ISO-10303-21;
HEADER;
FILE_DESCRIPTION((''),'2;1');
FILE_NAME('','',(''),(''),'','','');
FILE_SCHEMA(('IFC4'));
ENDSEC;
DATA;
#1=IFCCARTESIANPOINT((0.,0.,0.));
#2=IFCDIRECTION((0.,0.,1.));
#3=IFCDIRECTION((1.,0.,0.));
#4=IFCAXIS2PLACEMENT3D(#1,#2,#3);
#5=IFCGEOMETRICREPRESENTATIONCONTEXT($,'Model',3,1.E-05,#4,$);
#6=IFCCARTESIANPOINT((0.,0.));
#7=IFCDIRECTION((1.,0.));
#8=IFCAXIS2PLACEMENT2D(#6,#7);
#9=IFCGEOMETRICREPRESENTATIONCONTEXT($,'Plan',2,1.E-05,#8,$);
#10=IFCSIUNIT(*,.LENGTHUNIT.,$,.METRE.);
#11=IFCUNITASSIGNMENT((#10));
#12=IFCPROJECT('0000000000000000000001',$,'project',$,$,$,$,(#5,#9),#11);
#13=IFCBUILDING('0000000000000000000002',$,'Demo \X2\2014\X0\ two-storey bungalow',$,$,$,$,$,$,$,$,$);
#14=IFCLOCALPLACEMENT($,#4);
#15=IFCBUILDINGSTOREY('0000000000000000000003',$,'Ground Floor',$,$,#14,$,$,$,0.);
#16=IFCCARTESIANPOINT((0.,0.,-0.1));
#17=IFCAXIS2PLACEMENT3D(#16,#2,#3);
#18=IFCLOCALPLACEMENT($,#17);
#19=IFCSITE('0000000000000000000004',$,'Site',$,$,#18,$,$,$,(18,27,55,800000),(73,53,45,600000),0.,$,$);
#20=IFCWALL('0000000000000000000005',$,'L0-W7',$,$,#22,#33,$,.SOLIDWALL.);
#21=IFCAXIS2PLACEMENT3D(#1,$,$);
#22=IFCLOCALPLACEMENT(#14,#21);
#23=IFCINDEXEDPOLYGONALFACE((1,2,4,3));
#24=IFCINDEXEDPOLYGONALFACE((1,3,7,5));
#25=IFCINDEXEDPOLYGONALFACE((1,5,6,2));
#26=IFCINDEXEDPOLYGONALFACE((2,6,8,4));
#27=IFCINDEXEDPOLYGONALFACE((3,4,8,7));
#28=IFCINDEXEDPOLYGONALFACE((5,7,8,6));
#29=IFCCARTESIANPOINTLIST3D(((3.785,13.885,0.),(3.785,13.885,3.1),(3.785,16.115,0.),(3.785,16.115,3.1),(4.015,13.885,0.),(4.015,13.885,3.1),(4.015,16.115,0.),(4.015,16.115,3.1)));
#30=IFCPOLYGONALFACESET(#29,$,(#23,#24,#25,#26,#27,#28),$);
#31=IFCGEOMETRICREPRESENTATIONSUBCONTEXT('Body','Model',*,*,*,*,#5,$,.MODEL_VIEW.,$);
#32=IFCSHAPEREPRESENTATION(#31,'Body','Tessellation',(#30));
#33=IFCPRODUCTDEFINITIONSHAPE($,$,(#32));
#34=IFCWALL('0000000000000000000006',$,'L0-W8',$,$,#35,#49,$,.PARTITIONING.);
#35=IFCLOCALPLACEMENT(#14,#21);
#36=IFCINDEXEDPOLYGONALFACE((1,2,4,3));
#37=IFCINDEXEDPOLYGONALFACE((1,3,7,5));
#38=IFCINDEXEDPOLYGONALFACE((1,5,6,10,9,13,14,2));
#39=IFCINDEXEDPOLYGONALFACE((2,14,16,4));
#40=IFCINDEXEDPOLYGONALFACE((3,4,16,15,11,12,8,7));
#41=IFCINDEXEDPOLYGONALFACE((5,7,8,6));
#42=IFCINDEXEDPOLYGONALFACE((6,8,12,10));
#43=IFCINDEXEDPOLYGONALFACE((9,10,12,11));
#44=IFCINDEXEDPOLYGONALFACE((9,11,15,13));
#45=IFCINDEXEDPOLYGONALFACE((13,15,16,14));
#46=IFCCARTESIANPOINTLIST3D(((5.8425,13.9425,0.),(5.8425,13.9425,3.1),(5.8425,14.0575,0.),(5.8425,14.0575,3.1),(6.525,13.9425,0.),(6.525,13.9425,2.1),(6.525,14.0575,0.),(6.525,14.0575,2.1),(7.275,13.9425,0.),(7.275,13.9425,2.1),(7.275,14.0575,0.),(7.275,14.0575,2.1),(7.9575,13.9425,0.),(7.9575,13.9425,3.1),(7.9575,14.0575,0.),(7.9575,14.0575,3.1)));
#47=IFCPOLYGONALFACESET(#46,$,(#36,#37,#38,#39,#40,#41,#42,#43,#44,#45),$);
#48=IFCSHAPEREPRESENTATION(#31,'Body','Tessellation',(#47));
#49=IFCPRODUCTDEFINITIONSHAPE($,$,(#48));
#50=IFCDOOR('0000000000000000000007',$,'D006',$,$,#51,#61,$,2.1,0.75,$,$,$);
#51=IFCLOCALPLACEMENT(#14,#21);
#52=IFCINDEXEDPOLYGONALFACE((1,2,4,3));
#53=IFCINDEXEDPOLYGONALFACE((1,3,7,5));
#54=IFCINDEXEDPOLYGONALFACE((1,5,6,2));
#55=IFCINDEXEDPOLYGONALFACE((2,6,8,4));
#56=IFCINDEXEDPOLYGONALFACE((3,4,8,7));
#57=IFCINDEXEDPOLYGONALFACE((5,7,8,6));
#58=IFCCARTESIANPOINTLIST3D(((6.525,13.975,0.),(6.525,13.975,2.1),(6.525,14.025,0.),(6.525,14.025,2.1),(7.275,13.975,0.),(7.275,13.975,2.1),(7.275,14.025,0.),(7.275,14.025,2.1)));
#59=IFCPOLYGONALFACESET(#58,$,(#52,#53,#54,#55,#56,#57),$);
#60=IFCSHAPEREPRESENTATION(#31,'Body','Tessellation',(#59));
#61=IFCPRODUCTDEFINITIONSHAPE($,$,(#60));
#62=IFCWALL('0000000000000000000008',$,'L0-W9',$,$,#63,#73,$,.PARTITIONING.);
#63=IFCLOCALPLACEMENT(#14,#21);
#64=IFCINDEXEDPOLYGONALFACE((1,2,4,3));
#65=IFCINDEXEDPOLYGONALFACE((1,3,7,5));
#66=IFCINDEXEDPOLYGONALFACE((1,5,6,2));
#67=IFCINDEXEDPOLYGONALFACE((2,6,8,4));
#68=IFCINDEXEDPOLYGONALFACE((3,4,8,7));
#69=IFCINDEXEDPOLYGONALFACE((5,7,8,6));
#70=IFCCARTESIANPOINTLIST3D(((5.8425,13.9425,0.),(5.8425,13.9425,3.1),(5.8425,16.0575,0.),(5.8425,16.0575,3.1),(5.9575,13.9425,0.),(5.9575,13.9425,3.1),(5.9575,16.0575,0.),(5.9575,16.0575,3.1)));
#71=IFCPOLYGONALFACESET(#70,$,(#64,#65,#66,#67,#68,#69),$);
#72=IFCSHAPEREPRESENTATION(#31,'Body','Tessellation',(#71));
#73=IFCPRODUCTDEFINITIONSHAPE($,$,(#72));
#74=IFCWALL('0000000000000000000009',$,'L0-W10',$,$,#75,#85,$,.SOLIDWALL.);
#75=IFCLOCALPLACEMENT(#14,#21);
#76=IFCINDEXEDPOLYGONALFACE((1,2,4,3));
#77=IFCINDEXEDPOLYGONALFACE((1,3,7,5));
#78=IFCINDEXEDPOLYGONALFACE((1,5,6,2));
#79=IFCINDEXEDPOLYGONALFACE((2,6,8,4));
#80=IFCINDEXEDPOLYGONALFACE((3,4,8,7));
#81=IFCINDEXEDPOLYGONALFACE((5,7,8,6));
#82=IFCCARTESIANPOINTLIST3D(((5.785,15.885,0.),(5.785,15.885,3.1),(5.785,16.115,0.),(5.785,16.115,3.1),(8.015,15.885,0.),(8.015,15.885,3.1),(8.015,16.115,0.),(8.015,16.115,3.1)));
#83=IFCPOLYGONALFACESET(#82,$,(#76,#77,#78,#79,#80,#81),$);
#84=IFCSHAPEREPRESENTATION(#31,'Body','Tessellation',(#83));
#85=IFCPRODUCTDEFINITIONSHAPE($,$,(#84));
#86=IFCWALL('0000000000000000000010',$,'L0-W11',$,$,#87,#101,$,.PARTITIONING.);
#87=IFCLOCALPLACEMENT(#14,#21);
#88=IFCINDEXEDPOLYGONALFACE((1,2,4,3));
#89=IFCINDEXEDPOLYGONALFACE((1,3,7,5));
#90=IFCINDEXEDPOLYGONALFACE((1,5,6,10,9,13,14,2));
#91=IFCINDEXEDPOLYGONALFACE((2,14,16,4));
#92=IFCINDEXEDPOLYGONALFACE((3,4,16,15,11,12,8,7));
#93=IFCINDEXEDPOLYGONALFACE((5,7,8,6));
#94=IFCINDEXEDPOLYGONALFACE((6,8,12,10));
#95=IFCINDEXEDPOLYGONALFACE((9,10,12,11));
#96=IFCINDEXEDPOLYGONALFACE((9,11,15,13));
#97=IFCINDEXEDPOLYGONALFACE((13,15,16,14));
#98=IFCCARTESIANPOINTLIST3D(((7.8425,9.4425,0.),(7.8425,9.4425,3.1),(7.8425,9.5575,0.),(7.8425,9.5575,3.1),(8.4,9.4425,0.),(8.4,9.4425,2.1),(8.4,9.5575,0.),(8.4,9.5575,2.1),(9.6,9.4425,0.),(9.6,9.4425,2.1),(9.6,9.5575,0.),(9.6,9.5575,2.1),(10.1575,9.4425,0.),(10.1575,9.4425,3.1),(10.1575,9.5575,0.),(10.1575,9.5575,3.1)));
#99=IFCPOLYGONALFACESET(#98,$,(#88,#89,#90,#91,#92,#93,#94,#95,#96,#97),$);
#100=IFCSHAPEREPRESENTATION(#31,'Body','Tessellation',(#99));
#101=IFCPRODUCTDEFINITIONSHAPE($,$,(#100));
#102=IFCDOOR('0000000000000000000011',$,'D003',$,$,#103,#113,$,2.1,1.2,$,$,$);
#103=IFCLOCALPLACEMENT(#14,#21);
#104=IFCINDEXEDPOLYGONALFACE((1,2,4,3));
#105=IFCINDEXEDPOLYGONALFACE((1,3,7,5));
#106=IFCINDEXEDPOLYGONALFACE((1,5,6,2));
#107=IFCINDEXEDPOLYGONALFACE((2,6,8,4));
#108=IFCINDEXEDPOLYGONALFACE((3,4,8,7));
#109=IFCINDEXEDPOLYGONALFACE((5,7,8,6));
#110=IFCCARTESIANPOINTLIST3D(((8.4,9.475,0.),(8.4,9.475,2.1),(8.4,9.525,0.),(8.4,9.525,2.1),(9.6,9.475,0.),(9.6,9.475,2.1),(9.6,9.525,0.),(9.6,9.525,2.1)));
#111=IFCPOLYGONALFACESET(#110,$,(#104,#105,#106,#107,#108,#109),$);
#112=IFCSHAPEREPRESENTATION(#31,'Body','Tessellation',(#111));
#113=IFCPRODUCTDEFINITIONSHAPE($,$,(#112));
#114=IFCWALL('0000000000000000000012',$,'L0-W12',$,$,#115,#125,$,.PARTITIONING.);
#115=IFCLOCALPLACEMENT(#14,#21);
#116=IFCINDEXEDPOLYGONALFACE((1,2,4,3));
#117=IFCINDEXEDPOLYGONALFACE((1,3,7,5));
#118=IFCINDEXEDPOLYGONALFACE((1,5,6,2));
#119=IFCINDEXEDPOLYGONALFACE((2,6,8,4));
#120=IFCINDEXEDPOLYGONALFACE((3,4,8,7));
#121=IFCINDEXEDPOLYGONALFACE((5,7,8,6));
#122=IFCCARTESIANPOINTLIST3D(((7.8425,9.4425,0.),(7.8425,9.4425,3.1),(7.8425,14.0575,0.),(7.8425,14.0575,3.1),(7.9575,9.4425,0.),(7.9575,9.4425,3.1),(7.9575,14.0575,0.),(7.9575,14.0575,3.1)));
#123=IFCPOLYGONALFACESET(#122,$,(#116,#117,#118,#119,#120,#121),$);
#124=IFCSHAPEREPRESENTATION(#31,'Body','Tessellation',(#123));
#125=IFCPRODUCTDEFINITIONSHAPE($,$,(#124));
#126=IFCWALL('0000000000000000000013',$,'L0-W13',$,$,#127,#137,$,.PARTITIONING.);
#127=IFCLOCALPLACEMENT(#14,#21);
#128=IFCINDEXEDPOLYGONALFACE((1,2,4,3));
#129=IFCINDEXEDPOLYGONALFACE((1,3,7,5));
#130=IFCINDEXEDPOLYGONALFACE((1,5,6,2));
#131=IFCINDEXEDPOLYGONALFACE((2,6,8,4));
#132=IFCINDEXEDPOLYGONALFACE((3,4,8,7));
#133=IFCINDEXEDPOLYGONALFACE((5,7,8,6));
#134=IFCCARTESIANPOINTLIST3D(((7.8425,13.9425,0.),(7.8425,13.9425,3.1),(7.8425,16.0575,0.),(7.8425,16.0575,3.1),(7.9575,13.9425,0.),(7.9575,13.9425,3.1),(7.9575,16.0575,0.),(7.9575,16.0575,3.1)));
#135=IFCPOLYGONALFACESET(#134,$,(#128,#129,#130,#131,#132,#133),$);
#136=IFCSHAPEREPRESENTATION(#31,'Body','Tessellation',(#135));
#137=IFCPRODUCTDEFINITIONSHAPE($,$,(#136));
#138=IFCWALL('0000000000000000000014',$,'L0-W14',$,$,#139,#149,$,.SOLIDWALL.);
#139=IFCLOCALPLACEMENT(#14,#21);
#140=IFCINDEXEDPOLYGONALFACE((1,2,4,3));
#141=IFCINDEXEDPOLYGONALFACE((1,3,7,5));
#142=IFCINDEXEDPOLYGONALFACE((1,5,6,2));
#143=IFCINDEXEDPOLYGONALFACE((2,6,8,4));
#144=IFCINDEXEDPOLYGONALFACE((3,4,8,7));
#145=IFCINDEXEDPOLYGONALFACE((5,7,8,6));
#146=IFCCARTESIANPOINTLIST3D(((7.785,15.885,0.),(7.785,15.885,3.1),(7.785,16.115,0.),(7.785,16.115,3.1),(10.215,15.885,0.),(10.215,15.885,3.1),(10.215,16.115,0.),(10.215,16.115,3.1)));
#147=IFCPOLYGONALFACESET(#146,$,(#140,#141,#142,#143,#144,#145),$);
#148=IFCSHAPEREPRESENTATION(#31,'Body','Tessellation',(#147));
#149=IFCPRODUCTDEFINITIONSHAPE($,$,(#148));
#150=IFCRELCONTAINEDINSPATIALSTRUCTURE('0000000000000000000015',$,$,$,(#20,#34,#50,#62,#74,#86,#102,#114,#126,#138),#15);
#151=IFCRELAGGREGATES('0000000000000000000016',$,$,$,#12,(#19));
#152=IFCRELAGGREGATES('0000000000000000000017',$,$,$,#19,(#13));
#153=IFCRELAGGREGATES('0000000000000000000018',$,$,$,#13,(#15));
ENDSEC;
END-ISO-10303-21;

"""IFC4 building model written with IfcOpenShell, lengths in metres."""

from ifc_helpers import new_model, si_unit, frame, origin_with_axes, origin_2d_with_axis, place, context, subcontext, project, spatial, line, indexed_curve, outline, extrude, element, fill, save


model = new_model("IFC4")

# Units and contexts
model_context = context("Model", 3, precision=1e-05, world=origin_with_axes())
plan_context = context("Plan", 2, precision=1e-05, world=origin_2d_with_axis())
body_context = subcontext(model_context, "Body", "Model", "MODEL_VIEW")
ifc_project = project(units=[si_unit("LENGTHUNIT", "METRE")], contexts=[model_context, plan_context])

# Site, building, storey
site_placement = place(None, frame((0.0, 0.0, -0.1), z_axis=(0.0, 0.0, 1.0), x_axis=(1.0, 0.0, 0.0)))
site = spatial("IfcSite", under=ifc_project, at=site_placement, Name="Site", RefLatitude=(18, 27, 55, 800000), RefLongitude=(73, 53, 45, 600000), RefElevation=0.0)
building = spatial("IfcBuilding", under=site, Name="Demo — two-storey bungalow")
storey_placement = place(None, origin_with_axes())
storey = spatial("IfcBuildingStorey", under=building, at=storey_placement, Name="Ground Floor", Elevation=0.0)

# Wall
wall_1_placement = place(storey_placement, origin_with_axes())
element("IfcWall", 1, at=wall_1_placement, inside=storey, Name="L0-W7", PredefinedType="SOLIDWALL", context=body_context, shape_type="SweptSolid", body=[
    extrude(outline(indexed_curve([(4.015, 16.115), (4.015, 13.885), (3.785, 13.885), (3.785, 16.115)], segments=[line(1, 2, 3, 4, 1)])), origin_with_axes(), (0.0, 0.0, 1.0), 3.1),
])

# Wall, opening, door
wall_2_placement = place(storey_placement, origin_with_axes())
wall_2 = element("IfcWall", 2, at=wall_2_placement, inside=storey, Name="L0-W8", PredefinedType="PARTITIONING", context=body_context, shape_type="SweptSolid", body=[
    extrude(outline(indexed_curve([(7.9575, 13.9425), (5.8425, 13.9425), (5.8425, 14.0575), (7.9575, 14.0575)], segments=[line(1, 2, 3, 4, 1)])), origin_with_axes(), (0.0, 0.0, 1.0), 3.1),
])
opening_1_placement = place(wall_2_placement, origin_with_axes())
opening_1 = element("IfcOpeningElement", 3, at=opening_1_placement, cuts=wall_2, context=body_context, shape_type="SweptSolid", body=[
    extrude(outline(indexed_curve([(7.275, 13.8925), (6.525, 13.8925), (6.525, 14.1075), (7.275, 14.1075)], segments=[line(1, 2, 3, 4, 1)])), origin_with_axes(), (0.0, 0.0, 1.0), 2.1),
])
door_1_placement = place(storey_placement, origin_with_axes())
door_1 = element("IfcDoor", 4, at=door_1_placement, inside=storey, Name="D006", OverallHeight=2.1, OverallWidth=0.75, context=body_context, shape_type="SweptSolid", body=[
    extrude(outline(indexed_curve([(7.275, 13.975), (6.525, 13.975), (6.525, 14.025), (7.275, 14.025)], segments=[line(1, 2, 3, 4, 1)])), origin_with_axes(), (0.0, 0.0, 1.0), 2.1),
])
fill(opening_1, door_1)

# Walls
wall_3_placement = place(storey_placement, origin_with_axes())
element("IfcWall", 5, at=wall_3_placement, inside=storey, Name="L0-W9", PredefinedType="PARTITIONING", context=body_context, shape_type="SweptSolid", body=[
    extrude(outline(indexed_curve([(5.8425, 13.9425), (5.8425, 16.0575), (5.9575, 16.0575), (5.9575, 13.9425)], segments=[line(1, 2, 3, 4, 1)])), origin_with_axes(), (0.0, 0.0, 1.0), 3.1),
])
wall_4_placement = place(storey_placement, origin_with_axes())
element("IfcWall", 6, at=wall_4_placement, inside=storey, Name="L0-W10", PredefinedType="SOLIDWALL", context=body_context, shape_type="SweptSolid", body=[
    extrude(outline(indexed_curve([(8.015, 15.885), (5.785, 15.885), (5.785, 16.115), (8.015, 16.115)], segments=[line(1, 2, 3, 4, 1)])), origin_with_axes(), (0.0, 0.0, 1.0), 3.1),
])

# Wall, opening, door
wall_5_placement = place(storey_placement, origin_with_axes())
wall_5 = element("IfcWall", 7, at=wall_5_placement, inside=storey, Name="L0-W11", PredefinedType="PARTITIONING", context=body_context, shape_type="SweptSolid", body=[
    extrude(outline(indexed_curve([(10.1575, 9.4425), (7.8425, 9.4425), (7.8425, 9.5575), (10.1575, 9.5575)], segments=[line(1, 2, 3, 4, 1)])), origin_with_axes(), (0.0, 0.0, 1.0), 3.1),
])
opening_2_placement = place(wall_5_placement, origin_with_axes())
opening_2 = element("IfcOpeningElement", 8, at=opening_2_placement, cuts=wall_5, context=body_context, shape_type="SweptSolid", body=[
    extrude(outline(indexed_curve([(9.6, 9.3925), (8.4, 9.3925), (8.4, 9.6075), (9.6, 9.6075)], segments=[line(1, 2, 3, 4, 1)])), origin_with_axes(), (0.0, 0.0, 1.0), 2.1),
])
door_2_placement = place(storey_placement, origin_with_axes())
door_2 = element("IfcDoor", 9, at=door_2_placement, inside=storey, Name="D003", OverallHeight=2.1, OverallWidth=1.2, context=body_context, shape_type="SweptSolid", body=[
    extrude(outline(indexed_curve([(9.6, 9.475), (8.4, 9.475), (8.4, 9.525), (9.6, 9.525)], segments=[line(1, 2, 3, 4, 1)])), origin_with_axes(), (0.0, 0.0, 1.0), 2.1),
])
fill(opening_2, door_2)

# Walls
wall_6_placement = place(storey_placement, origin_with_axes())
element("IfcWall", 10, at=wall_6_placement, inside=storey, Name="L0-W12", PredefinedType="PARTITIONING", context=body_context, shape_type="SweptSolid", body=[
    extrude(outline(indexed_curve([(7.8425, 9.4425), (7.8425, 14.0575), (7.9575, 14.0575), (7.9575, 9.4425)], segments=[line(1, 2, 3, 4, 1)])), origin_with_axes(), (0.0, 0.0, 1.0), 3.1),
])
wall_7_placement = place(storey_placement, origin_with_axes())
element("IfcWall", 11, at=wall_7_placement, inside=storey, Name="L0-W13", PredefinedType="PARTITIONING", context=body_context, shape_type="SweptSolid", body=[
    extrude(outline(indexed_curve([(7.8425, 13.9425), (7.8425, 16.0575), (7.9575, 16.0575), (7.9575, 13.9425)], segments=[line(1, 2, 3, 4, 1)])), origin_with_axes(), (0.0, 0.0, 1.0), 3.1),
])
wall_8_placement = place(storey_placement, origin_with_axes())
element("IfcWall", 12, at=wall_8_placement, inside=storey, Name="L0-W14", PredefinedType="SOLIDWALL", context=body_context, shape_type="SweptSolid", body=[
    extrude(outline(indexed_curve([(10.215, 15.885), (7.785, 15.885), (7.785, 16.115), (10.215, 16.115)], segments=[line(1, 2, 3, 4, 1)])), origin_with_axes(), (0.0, 0.0, 1.0), 3.1),
])

save(model, "model.ifc")
